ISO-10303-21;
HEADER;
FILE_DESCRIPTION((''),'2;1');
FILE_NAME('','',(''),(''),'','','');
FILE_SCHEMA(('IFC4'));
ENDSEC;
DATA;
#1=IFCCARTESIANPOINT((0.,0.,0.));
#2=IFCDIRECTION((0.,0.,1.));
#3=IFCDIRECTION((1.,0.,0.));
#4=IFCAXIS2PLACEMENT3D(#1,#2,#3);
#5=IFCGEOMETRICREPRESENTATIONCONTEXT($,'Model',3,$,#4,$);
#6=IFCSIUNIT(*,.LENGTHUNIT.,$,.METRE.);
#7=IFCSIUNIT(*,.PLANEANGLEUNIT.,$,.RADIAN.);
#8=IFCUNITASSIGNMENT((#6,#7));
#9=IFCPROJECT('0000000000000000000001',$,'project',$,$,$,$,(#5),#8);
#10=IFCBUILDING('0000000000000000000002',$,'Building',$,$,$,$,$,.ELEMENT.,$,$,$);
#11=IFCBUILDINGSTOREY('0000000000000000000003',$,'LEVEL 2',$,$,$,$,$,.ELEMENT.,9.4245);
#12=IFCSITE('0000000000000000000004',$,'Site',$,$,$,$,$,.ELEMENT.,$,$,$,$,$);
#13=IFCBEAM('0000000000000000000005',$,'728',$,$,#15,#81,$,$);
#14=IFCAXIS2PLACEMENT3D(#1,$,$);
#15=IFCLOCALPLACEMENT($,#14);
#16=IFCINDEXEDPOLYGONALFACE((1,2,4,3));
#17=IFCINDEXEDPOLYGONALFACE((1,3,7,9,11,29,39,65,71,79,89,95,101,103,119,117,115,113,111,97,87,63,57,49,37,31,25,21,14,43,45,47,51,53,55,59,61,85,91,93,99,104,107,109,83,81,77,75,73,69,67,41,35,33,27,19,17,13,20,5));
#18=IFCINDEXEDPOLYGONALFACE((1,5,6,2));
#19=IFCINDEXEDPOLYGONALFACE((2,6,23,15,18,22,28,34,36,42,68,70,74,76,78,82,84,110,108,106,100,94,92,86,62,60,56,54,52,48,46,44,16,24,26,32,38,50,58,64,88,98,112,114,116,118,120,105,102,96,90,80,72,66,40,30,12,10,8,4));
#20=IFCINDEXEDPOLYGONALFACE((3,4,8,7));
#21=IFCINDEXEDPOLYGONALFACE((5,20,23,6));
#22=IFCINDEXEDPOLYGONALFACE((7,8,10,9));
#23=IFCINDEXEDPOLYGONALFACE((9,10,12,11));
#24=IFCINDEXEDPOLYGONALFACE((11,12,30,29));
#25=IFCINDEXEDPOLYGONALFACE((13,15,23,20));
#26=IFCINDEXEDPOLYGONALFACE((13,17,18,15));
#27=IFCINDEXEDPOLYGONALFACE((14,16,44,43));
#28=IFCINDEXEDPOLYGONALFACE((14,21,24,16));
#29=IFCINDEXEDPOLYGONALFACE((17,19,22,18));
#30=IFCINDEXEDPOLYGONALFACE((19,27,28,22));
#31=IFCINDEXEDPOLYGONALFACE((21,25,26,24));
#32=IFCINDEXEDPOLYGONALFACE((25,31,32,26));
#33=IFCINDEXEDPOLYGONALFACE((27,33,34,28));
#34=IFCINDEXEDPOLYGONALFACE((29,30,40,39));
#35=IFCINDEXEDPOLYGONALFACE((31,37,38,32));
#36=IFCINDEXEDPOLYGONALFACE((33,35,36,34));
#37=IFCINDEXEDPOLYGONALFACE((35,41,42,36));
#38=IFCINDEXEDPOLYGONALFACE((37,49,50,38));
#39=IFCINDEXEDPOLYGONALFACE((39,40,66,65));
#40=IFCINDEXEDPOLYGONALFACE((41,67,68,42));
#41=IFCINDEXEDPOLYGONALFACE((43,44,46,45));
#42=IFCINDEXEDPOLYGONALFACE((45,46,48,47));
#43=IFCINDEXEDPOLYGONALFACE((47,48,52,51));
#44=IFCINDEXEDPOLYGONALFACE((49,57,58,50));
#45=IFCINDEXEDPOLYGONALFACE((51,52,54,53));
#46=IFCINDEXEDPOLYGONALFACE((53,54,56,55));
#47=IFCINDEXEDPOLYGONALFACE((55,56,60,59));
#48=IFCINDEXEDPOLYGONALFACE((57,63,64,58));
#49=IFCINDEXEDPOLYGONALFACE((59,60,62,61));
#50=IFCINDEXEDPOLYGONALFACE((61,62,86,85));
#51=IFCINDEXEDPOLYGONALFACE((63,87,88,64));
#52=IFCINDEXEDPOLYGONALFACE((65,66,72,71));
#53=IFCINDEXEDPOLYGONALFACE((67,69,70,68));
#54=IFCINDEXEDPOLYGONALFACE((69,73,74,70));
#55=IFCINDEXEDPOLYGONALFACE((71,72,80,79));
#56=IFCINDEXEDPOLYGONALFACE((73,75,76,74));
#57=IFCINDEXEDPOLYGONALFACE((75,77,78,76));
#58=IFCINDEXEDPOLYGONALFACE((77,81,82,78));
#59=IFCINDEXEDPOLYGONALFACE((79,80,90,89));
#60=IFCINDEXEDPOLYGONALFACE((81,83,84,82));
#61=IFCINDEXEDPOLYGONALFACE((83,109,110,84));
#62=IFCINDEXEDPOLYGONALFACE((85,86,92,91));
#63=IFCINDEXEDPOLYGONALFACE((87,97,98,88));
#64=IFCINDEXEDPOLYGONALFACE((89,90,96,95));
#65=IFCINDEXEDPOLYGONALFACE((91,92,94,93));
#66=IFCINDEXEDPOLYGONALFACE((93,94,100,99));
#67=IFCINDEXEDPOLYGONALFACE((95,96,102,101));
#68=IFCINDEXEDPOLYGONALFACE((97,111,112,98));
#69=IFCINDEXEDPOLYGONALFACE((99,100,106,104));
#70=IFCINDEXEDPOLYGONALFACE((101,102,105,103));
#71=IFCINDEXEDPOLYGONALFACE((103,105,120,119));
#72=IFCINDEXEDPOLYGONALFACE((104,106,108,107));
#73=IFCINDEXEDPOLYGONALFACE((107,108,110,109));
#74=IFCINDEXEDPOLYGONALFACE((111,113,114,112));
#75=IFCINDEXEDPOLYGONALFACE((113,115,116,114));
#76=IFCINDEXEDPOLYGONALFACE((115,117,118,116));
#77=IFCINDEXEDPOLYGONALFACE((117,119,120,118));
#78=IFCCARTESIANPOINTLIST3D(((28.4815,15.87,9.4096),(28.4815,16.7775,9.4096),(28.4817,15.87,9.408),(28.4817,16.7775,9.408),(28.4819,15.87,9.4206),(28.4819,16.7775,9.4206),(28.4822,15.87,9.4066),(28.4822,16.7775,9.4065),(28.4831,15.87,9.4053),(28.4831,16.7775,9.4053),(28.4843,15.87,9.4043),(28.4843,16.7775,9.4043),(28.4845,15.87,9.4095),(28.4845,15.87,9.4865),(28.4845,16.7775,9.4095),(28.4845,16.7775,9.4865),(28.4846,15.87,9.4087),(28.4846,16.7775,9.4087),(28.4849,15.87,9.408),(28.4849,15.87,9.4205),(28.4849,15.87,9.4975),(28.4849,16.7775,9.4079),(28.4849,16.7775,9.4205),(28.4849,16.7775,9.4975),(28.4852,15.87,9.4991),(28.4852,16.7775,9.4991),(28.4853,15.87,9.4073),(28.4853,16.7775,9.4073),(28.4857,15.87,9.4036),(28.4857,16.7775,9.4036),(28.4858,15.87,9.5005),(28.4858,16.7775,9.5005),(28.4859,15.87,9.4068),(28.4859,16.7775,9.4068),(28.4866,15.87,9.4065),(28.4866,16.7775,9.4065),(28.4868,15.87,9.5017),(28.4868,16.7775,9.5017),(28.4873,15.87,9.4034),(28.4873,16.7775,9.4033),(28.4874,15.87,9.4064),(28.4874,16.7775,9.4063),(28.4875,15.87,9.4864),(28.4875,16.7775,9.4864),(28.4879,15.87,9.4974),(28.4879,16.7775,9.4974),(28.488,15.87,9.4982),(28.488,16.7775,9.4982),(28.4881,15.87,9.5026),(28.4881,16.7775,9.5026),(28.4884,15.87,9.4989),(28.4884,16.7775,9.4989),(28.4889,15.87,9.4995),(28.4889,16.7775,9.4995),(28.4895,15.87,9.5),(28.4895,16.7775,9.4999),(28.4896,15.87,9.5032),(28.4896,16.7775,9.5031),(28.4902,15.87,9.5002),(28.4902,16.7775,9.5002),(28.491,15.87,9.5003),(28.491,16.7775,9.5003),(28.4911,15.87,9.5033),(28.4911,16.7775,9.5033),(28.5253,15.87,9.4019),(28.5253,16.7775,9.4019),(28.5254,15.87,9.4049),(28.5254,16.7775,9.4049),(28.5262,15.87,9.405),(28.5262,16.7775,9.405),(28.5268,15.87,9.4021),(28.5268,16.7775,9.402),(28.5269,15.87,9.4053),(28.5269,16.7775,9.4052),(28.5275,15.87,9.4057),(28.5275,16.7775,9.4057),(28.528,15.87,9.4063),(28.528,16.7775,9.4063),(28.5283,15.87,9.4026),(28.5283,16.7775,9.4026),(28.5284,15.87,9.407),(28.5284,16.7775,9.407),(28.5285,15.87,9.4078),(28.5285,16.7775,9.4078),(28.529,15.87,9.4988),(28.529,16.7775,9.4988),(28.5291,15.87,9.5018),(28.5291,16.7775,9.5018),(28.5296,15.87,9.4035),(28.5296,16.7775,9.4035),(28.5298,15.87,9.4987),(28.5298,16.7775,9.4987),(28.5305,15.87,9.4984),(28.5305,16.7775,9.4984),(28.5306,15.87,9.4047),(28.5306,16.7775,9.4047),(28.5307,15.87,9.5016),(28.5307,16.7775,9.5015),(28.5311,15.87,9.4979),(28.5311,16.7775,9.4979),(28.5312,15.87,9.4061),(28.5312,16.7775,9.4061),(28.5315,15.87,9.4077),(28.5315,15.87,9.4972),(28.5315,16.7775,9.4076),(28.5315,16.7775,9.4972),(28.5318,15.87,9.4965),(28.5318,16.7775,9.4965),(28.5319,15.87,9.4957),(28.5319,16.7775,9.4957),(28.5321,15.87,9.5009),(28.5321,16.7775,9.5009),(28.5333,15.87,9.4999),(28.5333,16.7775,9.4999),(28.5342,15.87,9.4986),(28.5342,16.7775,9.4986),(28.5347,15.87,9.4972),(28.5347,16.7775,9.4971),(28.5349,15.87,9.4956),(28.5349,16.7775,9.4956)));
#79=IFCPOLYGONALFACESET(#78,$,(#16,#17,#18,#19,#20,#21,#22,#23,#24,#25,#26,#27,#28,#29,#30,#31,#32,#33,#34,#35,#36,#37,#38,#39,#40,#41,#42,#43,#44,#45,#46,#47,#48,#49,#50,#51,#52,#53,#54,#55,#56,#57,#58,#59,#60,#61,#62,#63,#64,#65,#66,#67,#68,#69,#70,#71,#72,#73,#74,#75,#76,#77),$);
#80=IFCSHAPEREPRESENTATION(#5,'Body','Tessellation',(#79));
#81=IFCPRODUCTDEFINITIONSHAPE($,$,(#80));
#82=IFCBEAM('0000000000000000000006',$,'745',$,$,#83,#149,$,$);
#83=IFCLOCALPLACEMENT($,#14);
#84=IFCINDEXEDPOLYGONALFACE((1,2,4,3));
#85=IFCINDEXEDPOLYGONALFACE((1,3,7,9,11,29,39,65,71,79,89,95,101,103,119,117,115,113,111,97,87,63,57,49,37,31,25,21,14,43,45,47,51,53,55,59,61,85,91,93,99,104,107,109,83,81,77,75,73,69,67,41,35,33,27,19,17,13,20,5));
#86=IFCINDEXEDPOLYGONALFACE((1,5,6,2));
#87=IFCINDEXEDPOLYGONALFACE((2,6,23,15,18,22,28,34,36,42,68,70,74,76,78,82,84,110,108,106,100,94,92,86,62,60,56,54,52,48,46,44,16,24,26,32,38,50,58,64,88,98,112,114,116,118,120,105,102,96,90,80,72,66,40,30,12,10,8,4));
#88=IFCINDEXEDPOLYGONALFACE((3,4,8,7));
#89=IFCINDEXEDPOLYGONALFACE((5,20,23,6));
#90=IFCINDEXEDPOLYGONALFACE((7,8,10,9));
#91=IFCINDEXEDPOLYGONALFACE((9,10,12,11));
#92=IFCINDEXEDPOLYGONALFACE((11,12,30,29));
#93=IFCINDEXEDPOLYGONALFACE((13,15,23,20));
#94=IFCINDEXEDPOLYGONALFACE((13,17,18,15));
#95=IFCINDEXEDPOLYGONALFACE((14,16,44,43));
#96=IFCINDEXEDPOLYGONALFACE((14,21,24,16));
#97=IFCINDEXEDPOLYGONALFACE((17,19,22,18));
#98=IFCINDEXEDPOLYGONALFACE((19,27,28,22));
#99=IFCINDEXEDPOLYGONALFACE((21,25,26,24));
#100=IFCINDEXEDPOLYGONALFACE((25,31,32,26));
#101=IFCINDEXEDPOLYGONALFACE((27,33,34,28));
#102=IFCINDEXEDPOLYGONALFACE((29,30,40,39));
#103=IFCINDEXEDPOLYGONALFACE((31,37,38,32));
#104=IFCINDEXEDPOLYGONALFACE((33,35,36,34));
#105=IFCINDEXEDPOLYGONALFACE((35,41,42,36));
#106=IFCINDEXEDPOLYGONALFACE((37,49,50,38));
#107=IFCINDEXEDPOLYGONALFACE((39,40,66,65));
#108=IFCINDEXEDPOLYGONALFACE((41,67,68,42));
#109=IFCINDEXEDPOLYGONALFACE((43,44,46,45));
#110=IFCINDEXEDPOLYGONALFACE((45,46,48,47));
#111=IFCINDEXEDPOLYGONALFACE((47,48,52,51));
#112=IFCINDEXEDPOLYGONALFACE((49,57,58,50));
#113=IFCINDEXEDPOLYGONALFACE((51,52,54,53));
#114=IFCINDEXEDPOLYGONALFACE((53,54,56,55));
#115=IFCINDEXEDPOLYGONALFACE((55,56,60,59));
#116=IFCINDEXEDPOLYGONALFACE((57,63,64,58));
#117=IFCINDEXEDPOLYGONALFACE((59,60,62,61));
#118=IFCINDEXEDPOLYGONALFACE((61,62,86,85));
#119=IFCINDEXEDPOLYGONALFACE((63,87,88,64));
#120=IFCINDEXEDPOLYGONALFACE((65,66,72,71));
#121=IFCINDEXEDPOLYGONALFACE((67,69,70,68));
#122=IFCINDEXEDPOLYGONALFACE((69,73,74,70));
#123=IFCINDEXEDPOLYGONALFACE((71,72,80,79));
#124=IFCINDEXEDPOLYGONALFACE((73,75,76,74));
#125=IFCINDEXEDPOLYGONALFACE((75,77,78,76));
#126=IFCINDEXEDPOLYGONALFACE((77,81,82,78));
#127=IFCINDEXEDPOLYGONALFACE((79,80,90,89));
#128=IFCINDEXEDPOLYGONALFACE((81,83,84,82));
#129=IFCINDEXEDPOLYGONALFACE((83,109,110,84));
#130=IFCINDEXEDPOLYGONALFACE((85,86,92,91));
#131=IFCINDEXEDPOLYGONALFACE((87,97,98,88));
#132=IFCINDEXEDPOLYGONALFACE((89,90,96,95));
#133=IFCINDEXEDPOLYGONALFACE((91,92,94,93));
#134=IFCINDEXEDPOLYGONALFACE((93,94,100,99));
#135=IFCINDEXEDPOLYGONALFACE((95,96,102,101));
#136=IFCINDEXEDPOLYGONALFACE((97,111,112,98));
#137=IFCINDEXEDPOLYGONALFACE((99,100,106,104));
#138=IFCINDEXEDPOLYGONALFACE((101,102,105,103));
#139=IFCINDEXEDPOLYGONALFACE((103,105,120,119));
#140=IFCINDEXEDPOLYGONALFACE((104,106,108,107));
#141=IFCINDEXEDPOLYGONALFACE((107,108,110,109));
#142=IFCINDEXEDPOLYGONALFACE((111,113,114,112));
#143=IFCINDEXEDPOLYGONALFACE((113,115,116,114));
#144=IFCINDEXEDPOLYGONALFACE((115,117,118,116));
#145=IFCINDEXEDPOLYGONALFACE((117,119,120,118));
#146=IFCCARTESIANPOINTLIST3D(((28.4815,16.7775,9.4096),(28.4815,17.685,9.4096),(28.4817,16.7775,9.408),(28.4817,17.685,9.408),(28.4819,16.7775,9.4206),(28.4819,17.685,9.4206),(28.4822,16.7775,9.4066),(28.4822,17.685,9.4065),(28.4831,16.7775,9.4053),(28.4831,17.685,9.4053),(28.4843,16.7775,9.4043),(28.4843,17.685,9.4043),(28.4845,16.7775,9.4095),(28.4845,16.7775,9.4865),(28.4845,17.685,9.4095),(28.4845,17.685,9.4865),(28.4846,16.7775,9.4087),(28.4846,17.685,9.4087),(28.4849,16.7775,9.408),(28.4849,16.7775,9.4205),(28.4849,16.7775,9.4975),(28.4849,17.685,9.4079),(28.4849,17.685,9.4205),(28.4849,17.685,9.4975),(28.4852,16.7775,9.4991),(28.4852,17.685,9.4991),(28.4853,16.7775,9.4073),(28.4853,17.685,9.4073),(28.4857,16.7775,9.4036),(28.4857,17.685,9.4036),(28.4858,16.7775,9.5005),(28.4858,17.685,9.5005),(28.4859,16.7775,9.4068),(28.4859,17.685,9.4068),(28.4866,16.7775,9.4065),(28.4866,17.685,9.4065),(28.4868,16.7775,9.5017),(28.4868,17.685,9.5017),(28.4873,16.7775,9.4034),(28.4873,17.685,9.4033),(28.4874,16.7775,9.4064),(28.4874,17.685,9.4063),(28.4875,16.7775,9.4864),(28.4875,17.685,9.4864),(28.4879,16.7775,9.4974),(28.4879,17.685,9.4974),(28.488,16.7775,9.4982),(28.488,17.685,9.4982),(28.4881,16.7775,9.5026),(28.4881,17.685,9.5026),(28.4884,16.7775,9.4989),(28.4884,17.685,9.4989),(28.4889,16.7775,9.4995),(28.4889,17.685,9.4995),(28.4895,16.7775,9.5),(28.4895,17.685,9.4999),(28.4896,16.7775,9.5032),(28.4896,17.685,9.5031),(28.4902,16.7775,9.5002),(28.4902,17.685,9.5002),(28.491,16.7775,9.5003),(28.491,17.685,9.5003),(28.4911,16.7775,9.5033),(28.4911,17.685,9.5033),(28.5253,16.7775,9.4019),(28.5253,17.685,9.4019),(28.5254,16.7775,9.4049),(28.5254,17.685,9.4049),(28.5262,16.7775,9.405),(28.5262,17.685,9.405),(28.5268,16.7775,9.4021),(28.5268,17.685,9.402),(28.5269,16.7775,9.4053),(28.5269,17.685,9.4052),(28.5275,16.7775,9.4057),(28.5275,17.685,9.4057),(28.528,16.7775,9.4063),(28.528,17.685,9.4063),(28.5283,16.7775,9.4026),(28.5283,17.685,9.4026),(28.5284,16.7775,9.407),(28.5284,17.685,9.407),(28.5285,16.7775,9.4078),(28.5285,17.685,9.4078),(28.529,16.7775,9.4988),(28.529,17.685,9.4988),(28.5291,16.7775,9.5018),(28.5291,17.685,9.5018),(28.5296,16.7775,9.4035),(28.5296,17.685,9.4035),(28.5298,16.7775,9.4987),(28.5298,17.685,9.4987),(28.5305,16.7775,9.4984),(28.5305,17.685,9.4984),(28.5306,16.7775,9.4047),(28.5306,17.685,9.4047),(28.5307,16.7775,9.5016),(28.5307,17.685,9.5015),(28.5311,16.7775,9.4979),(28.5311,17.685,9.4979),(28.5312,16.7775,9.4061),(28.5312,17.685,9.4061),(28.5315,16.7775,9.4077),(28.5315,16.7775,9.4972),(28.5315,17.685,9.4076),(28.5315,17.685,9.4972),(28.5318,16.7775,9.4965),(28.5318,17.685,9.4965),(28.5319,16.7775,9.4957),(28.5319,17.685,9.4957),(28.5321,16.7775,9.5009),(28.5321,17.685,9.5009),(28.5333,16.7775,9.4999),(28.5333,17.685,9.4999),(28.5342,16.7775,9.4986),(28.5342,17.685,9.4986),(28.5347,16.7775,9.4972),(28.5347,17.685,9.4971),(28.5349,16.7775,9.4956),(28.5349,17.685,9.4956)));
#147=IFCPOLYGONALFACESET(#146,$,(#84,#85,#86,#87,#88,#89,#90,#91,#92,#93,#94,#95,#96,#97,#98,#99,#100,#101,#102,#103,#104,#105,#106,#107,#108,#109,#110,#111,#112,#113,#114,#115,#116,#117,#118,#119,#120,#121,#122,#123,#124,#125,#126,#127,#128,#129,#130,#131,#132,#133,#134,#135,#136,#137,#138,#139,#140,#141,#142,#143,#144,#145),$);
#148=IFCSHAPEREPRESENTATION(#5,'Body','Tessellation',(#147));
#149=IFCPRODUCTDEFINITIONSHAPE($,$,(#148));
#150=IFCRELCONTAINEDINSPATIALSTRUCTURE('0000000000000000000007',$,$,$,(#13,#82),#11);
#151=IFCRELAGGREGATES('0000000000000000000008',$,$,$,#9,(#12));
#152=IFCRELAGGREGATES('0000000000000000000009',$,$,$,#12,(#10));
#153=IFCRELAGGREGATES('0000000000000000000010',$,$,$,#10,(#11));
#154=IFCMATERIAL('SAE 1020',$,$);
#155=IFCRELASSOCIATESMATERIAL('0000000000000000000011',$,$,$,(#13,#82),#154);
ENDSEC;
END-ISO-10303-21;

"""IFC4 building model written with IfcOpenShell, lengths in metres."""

from ifc_helpers import new_model, si_unit, frame, origin_with_axes, origin_2d_with_axis, place, context, project, spatial, c_section, extrude, material, material_profile, profile_set, profile_usage, element, save


model = new_model("IFC4")

# Units and contexts
model_context = context("Model", 3, world=origin_with_axes())
ifc_project = project(units=[si_unit("LENGTHUNIT", "METRE"), si_unit("PLANEANGLEUNIT", "RADIAN")], contexts=[model_context])

# Site, building, storey
site = spatial("IfcSite", under=ifc_project, Name="Site", CompositionType="ELEMENT")
building = spatial("IfcBuilding", under=site, Name="Building", CompositionType="ELEMENT")
storey = spatial("IfcBuildingStorey", under=building, Name="LEVEL 2", CompositionType="ELEMENT", Elevation=9.4245)

# Beams
ifc_material = material(Name="SAE 1020")
ifc_material_profile_1 = material_profile(ifc_material, c_section(Depth=0.1, Width=0.05, WallThickness=0.003, Girth=0.017, InternalFilletRadius=0.003, at=origin_2d_with_axis()))
ifc_profile_set_1 = profile_set([ifc_material_profile_1])
ifc_profile_usage_1 = profile_usage(ifc_profile_set_1, cardinal=10)
beam_1_placement = place(None, frame((28.5082, 15.87, 9.4526), z_axis=(0.0, 1.0, -0.00003), x_axis=(-0.999256, 0.000001, 0.038562)))
element("IfcBeam", 1, at=beam_1_placement, inside=storey, material=ifc_profile_usage_1, Name="728", context=model_context, shape_type="SweptSolid", body=[
    extrude(c_section(Depth=0.1, Width=0.05, WallThickness=0.003, Girth=0.017, InternalFilletRadius=0.003, at=origin_2d_with_axis()), origin_with_axes(), (0.0, 0.0, 1.0), 0.9075),
])
ifc_material_profile_2 = material_profile(ifc_material, c_section(Depth=0.1, Width=0.05, WallThickness=0.003, Girth=0.017, InternalFilletRadius=0.003, at=origin_2d_with_axis()))
ifc_profile_set_2 = profile_set([ifc_material_profile_2])
ifc_profile_usage_2 = profile_usage(ifc_profile_set_2, cardinal=10)
beam_2_placement = place(None, frame((28.5082, 16.7775, 9.4526), z_axis=(0.0, 1.0, -0.00003), x_axis=(-0.999256, 0.000001, 0.038562)))
element("IfcBeam", 2, at=beam_2_placement, inside=storey, material=ifc_profile_usage_2, Name="745", context=model_context, shape_type="SweptSolid", body=[
    extrude(c_section(Depth=0.1, Width=0.05, WallThickness=0.003, Girth=0.017, InternalFilletRadius=0.003, at=origin_2d_with_axis()), origin_with_axes(), (0.0, 0.0, 1.0), 0.9075),
])

save(model, "model.ifc")
